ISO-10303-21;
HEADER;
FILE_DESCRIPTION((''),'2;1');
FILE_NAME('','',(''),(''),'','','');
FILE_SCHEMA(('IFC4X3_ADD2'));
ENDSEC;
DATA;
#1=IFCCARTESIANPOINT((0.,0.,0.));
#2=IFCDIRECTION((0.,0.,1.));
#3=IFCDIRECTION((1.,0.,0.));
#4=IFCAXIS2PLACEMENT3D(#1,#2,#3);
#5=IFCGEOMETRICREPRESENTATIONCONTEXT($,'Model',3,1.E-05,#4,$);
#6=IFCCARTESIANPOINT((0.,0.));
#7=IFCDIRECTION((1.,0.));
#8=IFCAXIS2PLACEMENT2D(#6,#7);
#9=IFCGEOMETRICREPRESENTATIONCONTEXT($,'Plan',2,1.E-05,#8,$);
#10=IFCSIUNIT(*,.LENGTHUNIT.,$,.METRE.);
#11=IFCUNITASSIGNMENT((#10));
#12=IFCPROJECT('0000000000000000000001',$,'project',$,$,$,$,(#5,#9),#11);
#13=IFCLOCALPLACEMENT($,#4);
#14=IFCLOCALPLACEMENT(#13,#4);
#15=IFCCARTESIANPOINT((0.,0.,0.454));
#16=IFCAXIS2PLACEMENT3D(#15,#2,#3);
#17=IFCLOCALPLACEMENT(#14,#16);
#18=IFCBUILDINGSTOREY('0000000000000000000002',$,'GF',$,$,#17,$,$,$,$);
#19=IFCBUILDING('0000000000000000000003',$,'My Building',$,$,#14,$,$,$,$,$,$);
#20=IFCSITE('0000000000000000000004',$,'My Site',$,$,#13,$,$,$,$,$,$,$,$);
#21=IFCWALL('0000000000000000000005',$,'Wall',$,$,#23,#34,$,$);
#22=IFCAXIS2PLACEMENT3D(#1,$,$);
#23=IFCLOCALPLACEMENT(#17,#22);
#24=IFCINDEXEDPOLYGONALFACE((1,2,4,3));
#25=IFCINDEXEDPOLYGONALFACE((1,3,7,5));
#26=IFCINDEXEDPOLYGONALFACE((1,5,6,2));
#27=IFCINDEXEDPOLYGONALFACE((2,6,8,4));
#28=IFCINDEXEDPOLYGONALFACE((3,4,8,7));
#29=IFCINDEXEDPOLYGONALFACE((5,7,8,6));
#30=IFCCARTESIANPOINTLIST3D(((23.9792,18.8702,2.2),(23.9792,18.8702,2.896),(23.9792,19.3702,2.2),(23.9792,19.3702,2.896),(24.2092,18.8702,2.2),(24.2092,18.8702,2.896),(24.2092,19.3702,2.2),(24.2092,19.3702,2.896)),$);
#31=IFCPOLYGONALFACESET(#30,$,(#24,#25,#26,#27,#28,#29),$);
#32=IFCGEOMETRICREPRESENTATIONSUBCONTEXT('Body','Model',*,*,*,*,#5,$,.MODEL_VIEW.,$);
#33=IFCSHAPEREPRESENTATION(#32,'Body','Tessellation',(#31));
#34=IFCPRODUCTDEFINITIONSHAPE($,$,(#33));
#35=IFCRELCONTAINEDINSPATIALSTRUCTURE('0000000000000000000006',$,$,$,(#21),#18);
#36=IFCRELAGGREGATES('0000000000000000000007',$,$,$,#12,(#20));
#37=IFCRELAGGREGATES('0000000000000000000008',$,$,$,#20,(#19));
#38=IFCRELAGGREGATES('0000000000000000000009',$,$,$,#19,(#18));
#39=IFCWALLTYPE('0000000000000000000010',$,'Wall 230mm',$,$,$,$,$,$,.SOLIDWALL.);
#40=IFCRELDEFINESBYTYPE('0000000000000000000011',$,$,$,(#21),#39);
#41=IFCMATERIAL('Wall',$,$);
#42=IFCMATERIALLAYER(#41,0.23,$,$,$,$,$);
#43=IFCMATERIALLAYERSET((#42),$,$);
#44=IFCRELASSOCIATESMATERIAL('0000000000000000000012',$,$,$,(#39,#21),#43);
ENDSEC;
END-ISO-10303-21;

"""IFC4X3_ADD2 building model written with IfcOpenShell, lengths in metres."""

from ifc_helpers import new_model, si_unit, frame, origin_with_axes, origin_2d_with_axis, place, context, subcontext, project, spatial, indexed_curve, outline, extrude, clip, halfspace, material, layer, layer_set, layer_usage, type_object, element, save


model = new_model("IFC4X3_ADD2")

# Units and contexts
model_context = context("Model", 3, precision=1e-05, world=origin_with_axes())
plan_context = context("Plan", 2, precision=1e-05, world=origin_2d_with_axis())
body_context_1 = subcontext(model_context, "Body", "Model", "MODEL_VIEW")
ifc_project = project(units=[si_unit("LENGTHUNIT", "METRE")], contexts=[model_context, plan_context])

# Site, building, storey
site_placement = place(None, origin_with_axes())
site = spatial("IfcSite", under=ifc_project, at=site_placement, Name="My Site")
building_placement = place(site_placement, origin_with_axes())
building = spatial("IfcBuilding", under=site, at=building_placement, Name="My Building")
storey_placement = place(building_placement, frame((0.0, 0.0, 0.454), z_axis=(0.0, 0.0, 1.0), x_axis=(1.0, 0.0, 0.0)))
storey = spatial("IfcBuildingStorey", under=building, at=storey_placement, Name="GF")

# Shared definitions
ifc_material_1 = material(Name="Wall")

# Shared definitions
ifc_layer_1 = layer(ifc_material_1, 0.23)
ifc_layer_set_1 = layer_set([ifc_layer_1])
wall_type_1 = type_object("IfcWallType", Name="Wall 230mm", PredefinedType="SOLIDWALL", material=ifc_layer_set_1)

# Wall
ifc_layer_usage_1 = layer_usage(ifc_layer_set_1, "AXIS2", "POSITIVE", 0.0)
wall_1_placement = place(storey_placement, frame((23.9792, 19.3702, 2.2), z_axis=(0.0, 0.0, 1.0), x_axis=(0.0, -1.0, 0.0)))
element("IfcWall", 1, at=wall_1_placement, inside=storey, type_object=wall_type_1, material=ifc_layer_usage_1, Name="Wall", context=body_context_1, shape_type="Clipping", body=[
    clip(clip(extrude(outline(indexed_curve([(0.0, 0.0), (0.0, 0.23), (0.5, 0.23), (0.5, 0.0), (0.0, 0.0)], self_intersect=False)), origin_with_axes(), (0.0, 0.0, 1.0), 6.25), halfspace(frame((0.0, 0.0, 3.596), z_axis=(0.0, 0.0, 1.0), x_axis=(-1.0, 0.0, 0.0)), False)), halfspace(frame((0.0, 0.0, 0.696), z_axis=(0.0, 0.0, 1.0), x_axis=(-1.0, 0.0, 0.0)), False)),
])

save(model, "model.ifc")
